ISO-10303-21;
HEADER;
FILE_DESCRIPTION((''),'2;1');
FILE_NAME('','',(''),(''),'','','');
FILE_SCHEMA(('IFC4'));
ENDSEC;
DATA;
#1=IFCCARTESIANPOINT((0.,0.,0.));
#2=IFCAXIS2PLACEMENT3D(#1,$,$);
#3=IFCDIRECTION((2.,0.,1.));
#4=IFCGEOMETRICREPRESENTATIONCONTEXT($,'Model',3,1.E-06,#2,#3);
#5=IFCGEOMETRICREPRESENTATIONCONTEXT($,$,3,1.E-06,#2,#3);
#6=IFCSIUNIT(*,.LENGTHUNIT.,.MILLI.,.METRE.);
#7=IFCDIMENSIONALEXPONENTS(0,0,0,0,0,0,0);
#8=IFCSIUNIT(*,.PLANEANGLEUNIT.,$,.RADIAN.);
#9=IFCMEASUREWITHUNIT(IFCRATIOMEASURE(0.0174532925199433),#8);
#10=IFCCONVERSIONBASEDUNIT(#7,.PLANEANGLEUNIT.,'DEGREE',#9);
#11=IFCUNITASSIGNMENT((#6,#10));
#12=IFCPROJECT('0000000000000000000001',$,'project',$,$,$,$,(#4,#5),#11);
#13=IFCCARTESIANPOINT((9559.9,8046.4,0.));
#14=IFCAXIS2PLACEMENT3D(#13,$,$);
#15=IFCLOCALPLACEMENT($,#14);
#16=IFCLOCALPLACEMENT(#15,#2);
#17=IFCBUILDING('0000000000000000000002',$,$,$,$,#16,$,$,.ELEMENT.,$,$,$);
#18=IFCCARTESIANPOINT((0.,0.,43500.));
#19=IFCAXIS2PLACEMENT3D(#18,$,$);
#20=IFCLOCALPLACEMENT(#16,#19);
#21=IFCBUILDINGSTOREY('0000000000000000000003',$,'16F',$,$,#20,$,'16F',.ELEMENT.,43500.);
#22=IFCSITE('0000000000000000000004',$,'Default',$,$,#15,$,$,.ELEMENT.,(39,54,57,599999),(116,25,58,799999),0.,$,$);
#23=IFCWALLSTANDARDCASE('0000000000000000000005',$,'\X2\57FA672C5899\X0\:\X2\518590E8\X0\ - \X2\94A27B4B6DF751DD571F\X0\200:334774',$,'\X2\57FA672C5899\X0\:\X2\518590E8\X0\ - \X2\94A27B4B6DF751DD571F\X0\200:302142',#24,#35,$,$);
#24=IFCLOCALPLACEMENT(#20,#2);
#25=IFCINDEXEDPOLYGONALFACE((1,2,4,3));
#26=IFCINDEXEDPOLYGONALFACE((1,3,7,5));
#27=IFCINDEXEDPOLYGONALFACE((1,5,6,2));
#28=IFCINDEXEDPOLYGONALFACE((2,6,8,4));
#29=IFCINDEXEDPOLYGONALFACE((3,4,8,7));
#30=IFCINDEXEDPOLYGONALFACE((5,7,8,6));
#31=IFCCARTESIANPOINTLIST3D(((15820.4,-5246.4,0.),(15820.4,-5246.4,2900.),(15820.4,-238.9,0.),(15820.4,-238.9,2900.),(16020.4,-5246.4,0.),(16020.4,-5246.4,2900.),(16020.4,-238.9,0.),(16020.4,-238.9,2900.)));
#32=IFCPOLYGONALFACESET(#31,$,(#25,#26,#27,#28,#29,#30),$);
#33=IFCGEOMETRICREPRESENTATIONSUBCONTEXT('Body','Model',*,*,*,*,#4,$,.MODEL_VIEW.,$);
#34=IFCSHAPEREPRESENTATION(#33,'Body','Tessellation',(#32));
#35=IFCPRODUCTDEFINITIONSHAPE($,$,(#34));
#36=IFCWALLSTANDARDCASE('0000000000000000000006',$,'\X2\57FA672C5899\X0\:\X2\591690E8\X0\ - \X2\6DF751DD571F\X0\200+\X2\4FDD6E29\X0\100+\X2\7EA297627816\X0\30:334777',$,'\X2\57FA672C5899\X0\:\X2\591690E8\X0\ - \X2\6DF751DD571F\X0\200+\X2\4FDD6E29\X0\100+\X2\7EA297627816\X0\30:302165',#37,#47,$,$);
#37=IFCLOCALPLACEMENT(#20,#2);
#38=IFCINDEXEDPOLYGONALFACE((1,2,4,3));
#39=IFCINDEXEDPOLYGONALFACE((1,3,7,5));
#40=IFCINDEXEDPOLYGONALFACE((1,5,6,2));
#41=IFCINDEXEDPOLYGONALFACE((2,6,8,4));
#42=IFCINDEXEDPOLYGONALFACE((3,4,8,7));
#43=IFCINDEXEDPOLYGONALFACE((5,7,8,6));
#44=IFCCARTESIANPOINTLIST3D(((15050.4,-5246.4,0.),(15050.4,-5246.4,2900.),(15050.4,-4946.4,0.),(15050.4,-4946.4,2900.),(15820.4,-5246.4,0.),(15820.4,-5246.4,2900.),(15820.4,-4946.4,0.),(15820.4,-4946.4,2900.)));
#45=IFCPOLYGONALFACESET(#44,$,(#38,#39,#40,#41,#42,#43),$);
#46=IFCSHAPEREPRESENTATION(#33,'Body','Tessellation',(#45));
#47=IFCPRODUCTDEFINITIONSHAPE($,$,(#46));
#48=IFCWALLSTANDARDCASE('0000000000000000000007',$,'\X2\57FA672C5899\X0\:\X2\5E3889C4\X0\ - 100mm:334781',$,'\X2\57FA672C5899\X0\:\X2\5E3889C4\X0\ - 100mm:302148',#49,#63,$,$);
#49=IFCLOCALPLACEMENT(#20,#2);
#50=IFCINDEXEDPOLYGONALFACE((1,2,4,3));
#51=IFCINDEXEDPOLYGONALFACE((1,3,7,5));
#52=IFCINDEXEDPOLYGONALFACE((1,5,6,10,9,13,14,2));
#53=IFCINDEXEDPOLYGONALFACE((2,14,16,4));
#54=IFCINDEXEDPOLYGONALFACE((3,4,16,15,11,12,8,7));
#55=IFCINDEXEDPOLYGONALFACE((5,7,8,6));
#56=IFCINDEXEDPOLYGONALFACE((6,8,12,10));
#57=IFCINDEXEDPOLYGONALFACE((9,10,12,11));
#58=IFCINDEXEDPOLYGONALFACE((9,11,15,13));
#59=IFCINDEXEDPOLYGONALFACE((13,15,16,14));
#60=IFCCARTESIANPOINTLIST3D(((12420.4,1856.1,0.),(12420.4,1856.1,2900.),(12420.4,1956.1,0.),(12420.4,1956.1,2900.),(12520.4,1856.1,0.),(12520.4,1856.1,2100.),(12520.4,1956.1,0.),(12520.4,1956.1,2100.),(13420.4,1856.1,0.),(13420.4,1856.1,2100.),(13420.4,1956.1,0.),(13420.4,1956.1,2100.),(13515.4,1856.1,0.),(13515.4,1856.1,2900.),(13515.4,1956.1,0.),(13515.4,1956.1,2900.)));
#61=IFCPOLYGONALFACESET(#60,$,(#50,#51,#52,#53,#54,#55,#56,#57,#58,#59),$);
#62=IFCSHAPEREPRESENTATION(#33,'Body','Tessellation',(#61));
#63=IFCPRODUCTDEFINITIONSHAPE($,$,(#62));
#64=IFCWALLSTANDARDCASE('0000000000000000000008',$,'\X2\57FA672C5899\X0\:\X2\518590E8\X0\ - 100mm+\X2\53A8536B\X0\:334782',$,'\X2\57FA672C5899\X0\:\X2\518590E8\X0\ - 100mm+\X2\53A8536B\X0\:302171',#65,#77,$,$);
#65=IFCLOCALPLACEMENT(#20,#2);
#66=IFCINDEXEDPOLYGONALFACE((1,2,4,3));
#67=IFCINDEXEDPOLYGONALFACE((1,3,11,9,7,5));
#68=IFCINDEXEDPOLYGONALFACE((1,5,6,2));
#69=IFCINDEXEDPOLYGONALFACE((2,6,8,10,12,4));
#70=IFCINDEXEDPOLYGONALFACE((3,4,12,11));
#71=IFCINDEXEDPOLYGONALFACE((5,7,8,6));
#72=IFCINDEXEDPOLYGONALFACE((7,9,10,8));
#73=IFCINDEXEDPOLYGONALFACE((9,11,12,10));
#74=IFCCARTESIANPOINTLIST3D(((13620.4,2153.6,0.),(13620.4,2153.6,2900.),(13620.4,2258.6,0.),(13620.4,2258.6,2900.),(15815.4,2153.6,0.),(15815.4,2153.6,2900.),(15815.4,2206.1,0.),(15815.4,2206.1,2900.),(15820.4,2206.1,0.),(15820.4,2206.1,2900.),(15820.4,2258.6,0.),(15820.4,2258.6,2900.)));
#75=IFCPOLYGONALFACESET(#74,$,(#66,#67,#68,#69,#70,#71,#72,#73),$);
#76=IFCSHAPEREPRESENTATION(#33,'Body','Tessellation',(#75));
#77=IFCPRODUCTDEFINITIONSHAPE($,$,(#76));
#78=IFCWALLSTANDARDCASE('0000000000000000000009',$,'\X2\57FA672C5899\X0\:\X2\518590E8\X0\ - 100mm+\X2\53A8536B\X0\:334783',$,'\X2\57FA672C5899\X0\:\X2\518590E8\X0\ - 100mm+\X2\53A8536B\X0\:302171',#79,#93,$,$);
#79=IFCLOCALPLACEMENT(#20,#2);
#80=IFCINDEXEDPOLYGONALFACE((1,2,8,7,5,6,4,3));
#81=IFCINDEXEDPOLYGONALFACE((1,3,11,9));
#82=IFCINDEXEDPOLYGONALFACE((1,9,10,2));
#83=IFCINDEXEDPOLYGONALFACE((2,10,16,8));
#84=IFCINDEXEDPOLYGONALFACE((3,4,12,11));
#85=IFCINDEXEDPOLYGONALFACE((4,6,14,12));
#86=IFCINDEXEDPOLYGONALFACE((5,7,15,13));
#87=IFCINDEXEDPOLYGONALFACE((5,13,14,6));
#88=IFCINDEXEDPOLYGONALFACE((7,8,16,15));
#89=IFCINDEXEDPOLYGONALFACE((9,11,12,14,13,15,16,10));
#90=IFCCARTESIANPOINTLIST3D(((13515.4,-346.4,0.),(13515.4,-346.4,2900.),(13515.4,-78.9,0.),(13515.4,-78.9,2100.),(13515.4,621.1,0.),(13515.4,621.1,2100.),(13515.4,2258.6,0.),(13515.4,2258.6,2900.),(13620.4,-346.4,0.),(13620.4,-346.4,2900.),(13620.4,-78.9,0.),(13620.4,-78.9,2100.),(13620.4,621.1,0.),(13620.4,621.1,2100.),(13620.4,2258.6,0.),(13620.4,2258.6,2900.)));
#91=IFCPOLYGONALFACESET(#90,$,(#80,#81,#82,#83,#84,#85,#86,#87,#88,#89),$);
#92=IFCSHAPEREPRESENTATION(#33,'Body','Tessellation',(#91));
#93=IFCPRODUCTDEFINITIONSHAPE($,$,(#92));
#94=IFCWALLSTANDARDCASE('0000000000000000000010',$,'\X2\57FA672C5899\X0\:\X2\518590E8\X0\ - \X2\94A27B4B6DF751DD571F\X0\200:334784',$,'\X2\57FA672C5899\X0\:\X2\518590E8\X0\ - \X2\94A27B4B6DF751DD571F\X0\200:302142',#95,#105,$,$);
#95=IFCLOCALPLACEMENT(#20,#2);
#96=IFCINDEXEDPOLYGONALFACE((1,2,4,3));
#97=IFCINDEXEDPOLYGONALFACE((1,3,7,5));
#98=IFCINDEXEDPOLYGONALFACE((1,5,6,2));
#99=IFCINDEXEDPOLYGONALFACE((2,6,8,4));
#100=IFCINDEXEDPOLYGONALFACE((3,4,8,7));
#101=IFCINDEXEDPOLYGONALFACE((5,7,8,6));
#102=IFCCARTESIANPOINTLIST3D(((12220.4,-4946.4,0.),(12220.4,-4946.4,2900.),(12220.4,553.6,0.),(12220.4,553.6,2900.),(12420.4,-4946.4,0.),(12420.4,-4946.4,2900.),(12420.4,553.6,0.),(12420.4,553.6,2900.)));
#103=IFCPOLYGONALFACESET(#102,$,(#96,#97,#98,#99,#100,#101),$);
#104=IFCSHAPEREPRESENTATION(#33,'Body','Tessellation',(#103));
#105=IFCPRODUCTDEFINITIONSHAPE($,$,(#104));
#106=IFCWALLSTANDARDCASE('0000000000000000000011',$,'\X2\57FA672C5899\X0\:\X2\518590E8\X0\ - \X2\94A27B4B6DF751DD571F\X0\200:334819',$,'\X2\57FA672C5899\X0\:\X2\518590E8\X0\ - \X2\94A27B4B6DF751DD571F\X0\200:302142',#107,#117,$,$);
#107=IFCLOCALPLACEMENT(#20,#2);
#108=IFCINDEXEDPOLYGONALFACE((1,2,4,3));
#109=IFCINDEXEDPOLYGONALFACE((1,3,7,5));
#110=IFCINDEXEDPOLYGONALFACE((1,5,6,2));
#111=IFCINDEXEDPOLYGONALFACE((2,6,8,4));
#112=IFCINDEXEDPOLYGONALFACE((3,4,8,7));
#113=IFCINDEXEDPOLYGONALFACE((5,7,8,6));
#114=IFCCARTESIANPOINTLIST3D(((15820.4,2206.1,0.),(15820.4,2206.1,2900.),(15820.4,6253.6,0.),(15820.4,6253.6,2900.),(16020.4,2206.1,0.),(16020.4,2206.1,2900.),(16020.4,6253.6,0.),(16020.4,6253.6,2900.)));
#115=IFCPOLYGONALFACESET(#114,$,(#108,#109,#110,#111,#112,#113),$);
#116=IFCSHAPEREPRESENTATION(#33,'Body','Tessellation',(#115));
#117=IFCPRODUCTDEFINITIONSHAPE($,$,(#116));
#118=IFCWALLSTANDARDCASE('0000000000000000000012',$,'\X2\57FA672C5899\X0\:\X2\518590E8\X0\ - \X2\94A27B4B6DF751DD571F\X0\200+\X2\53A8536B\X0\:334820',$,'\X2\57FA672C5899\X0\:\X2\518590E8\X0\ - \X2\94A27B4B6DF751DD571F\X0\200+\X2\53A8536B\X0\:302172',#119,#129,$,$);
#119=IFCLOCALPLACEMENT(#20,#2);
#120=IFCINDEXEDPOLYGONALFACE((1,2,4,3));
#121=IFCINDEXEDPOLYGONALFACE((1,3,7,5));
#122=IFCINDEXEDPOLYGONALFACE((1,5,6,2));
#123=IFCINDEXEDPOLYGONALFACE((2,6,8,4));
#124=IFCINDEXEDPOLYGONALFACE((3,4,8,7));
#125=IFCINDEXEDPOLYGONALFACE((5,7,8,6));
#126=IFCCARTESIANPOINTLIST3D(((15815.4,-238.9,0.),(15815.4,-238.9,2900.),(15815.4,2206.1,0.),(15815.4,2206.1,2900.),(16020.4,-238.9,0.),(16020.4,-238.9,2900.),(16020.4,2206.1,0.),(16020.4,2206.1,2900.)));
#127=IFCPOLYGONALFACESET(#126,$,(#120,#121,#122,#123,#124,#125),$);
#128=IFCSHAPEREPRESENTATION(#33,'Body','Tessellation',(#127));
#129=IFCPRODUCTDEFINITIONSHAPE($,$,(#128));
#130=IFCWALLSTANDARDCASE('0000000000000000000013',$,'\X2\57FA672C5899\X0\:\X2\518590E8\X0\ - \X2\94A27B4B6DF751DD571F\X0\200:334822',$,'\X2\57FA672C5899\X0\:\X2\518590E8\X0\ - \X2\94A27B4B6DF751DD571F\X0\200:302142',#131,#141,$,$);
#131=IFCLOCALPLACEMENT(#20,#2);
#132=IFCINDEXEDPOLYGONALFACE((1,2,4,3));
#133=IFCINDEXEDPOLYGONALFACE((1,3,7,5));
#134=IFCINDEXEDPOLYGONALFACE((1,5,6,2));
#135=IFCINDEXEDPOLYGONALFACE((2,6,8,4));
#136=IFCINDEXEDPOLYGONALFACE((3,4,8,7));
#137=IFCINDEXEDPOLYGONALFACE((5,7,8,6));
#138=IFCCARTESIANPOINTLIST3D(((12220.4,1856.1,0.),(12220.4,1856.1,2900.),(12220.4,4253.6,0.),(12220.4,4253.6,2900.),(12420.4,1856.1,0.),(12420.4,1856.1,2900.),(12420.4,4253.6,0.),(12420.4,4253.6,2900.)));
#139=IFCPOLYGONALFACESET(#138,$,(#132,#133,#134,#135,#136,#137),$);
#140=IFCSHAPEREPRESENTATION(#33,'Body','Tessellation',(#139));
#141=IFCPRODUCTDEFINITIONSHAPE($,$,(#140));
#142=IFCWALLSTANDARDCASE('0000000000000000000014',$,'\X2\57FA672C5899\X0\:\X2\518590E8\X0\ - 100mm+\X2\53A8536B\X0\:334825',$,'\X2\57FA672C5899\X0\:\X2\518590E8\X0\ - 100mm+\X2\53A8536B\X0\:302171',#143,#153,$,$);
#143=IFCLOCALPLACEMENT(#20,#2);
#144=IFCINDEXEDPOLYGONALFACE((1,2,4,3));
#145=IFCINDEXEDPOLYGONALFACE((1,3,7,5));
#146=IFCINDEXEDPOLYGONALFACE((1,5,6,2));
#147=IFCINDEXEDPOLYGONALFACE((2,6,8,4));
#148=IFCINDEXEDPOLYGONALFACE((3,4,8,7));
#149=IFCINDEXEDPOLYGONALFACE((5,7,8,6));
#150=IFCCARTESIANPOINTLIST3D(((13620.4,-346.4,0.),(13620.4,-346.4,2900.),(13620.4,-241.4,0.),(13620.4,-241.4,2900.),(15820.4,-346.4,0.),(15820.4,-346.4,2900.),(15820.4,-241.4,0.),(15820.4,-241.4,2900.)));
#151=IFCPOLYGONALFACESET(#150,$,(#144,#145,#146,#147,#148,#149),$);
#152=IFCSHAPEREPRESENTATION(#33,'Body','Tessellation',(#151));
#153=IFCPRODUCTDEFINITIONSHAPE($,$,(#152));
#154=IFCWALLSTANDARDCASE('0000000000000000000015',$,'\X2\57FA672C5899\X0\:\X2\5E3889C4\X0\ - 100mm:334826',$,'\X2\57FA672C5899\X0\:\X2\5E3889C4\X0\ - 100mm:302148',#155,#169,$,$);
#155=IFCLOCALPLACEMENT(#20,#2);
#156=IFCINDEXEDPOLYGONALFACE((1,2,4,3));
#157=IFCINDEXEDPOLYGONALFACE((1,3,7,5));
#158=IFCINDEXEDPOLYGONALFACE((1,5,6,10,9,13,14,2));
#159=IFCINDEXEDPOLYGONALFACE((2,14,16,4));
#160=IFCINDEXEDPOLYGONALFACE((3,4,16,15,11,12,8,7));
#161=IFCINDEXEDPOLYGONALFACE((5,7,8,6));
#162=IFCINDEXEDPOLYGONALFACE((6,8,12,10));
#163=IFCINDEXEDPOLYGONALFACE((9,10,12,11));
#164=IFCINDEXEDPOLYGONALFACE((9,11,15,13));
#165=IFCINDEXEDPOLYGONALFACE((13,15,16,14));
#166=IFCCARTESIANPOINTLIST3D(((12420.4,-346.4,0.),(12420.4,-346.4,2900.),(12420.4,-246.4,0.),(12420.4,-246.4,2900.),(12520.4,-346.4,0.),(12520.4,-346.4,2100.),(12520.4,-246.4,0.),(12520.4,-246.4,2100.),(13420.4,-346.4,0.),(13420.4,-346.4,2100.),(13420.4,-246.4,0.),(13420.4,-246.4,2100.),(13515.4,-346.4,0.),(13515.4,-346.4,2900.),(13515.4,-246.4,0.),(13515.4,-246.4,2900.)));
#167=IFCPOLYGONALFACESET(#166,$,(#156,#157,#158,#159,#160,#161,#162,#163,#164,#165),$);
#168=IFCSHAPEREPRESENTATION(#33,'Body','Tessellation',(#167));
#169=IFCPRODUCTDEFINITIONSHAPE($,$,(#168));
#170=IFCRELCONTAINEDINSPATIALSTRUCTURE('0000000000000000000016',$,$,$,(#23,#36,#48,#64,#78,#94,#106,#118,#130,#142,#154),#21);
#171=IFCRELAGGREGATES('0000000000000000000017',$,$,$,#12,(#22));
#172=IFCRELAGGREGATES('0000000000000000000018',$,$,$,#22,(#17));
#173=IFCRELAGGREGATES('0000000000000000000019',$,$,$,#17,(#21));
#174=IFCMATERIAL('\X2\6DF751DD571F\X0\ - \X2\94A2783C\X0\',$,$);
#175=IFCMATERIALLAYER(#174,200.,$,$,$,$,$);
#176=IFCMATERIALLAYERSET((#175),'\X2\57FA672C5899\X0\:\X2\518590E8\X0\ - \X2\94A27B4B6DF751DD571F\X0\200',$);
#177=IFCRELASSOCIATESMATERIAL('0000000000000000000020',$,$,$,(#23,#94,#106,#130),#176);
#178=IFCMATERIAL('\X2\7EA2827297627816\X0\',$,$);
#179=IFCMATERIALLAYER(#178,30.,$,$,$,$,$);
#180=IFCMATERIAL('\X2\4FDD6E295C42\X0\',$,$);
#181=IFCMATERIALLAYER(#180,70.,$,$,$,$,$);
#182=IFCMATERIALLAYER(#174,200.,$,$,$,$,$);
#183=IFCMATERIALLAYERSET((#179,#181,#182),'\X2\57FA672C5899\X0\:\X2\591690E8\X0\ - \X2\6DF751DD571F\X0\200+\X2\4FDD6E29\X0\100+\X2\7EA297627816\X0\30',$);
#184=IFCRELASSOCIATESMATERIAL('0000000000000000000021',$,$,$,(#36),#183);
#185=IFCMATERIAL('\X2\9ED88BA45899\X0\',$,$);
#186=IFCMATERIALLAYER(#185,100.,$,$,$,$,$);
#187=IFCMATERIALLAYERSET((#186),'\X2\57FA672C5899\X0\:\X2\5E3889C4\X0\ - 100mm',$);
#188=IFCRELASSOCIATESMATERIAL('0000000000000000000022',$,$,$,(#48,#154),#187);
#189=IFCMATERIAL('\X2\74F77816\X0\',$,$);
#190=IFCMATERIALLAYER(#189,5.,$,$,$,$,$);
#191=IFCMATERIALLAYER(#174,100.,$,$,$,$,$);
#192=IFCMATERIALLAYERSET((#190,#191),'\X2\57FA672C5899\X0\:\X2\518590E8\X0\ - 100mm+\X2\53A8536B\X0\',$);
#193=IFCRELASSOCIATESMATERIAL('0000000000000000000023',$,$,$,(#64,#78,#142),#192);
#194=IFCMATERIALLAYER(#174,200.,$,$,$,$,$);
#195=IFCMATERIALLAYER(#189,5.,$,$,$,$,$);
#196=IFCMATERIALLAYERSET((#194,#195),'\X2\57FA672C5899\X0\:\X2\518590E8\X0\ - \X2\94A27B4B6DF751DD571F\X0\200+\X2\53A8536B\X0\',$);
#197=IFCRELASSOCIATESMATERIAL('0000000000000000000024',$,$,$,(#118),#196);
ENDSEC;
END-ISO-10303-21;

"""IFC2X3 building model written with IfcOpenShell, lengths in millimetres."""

from ifc_helpers import new_model, entity, si_unit, converted_unit, direction, frame, frame_2d, origin, place, context, subcontext, project, spatial, polyline, rectangle, outline, extrude, material, layer, layer_set, layer_usage, element, save


model = new_model("IFC2X3")

# Units and contexts
model_context = context("Model", 3, precision=1e-06, world=origin(), true_north=direction((2.0, 0.0, 1.0)))
context_of_model = context(None, 3, precision=1e-06, world=origin(), true_north=direction((2.0, 0.0, 1.0)))
body_context = subcontext(model_context, "Body", "Model", "MODEL_VIEW")
ifc_project = project(units=[si_unit("LENGTHUNIT", "METRE", prefix="MILLI"), converted_unit("PLANEANGLEUNIT", "DEGREE", entity("IfcRatioMeasure", 0.0174532925199433), si_unit("PLANEANGLEUNIT", "RADIAN"), dimensions=[0, 0, 0, 0, 0, 0, 0])], contexts=[model_context, context_of_model])

# Site, building, storey
site_placement = place(None, frame((9559.9, 8046.4, 0.0)))
site = spatial("IfcSite", under=ifc_project, at=site_placement, Name="Default", CompositionType="ELEMENT", RefLatitude=(39, 54, 57, 599999), RefLongitude=(116, 25, 58, 799999), RefElevation=0.0)
building_placement = place(site_placement, origin())
building = spatial("IfcBuilding", under=site, at=building_placement, CompositionType="ELEMENT")
storey_placement = place(building_placement, frame((0.0, 0.0, 43500.0)))
storey = spatial("IfcBuildingStorey", under=building, at=storey_placement, Name="16F", LongName="16F", CompositionType="ELEMENT", Elevation=43500.0)

# Walls
ifc_material_1 = material(Name="混凝土 - 钢砼")
ifc_layer_1 = layer(ifc_material_1, 200.0)
ifc_layer_set_1 = layer_set([ifc_layer_1], Name="基本墙:内部 - 钢筋混凝土200")
ifc_layer_usage_1 = layer_usage(ifc_layer_set_1, "AXIS2", "POSITIVE", -100.0)
wall_1_placement = place(storey_placement, frame((15920.4, -5246.4, 0.0), z_axis=(0.0, 0.0, 1.0), x_axis=(0.0, 1.0, 0.0)))
element("IfcWallStandardCase", 1, at=wall_1_placement, inside=storey, material=ifc_layer_usage_1, Name="基本墙:内部 - 钢筋混凝土200:334774", ObjectType="基本墙:内部 - 钢筋混凝土200:302142", context=body_context, shape_type="SweptSolid", body=[
    extrude(rectangle(XDim=5007.5, YDim=200.0, at=frame_2d((2503.8, 0.0), x_axis=(-1.0, 0.0))), origin(), (0.0, 0.0, 1.0), 2900.0),
])
ifc_material_2 = material(Name="红色面砖")
ifc_layer_2 = layer(ifc_material_2, 30.0)
ifc_material_3 = material(Name="保温层")
ifc_layer_3 = layer(ifc_material_3, 70.0)
ifc_layer_4 = layer(ifc_material_1, 200.0)
ifc_layer_set_2 = layer_set([ifc_layer_2, ifc_layer_3, ifc_layer_4], Name="基本墙:外部 - 混凝土200+保温100+红面砖30")
ifc_layer_usage_2 = layer_usage(ifc_layer_set_2, "AXIS2", "NEGATIVE", 150.0)
wall_2_placement = place(storey_placement, frame((15820.4, -5096.4, 0.0), z_axis=(0.0, 0.0, 1.0), x_axis=(-1.0, 0.0, 0.0)))
element("IfcWallStandardCase", 2, at=wall_2_placement, inside=storey, material=ifc_layer_usage_2, Name="基本墙:外部 - 混凝土200+保温100+红面砖30:334777", ObjectType="基本墙:外部 - 混凝土200+保温100+红面砖30:302165", context=body_context, shape_type="SweptSolid", body=[
    extrude(rectangle(XDim=770.0, YDim=300.0, at=frame_2d((385.0, 0.0), x_axis=(-1.0, 0.0))), origin(), (0.0, 0.0, 1.0), 2900.0),
])

# Wall, opening
ifc_material_4 = material(Name="默认墙")
ifc_layer_5 = layer(ifc_material_4, 100.0)
ifc_layer_set_3 = layer_set([ifc_layer_5], Name="基本墙:常规 - 100mm")
ifc_layer_usage_3 = layer_usage(ifc_layer_set_3, "AXIS2", "POSITIVE", -50.0)
wall_3_placement = place(storey_placement, frame((13515.4, 1906.1, 0.0), z_axis=(0.0, 0.0, 1.0), x_axis=(-1.0, 0.0, 0.0)))
wall_3 = element("IfcWallStandardCase", 3, at=wall_3_placement, inside=storey, material=ifc_layer_usage_3, Name="基本墙:常规 - 100mm:334781", ObjectType="基本墙:常规 - 100mm:302148", context=body_context, shape_type="SweptSolid", body=[
    extrude(rectangle(XDim=1095.0, YDim=100.0, at=frame_2d((547.5, 0.0), x_axis=(-1.0, 0.0))), origin(), (0.0, 0.0, 1.0), 2900.0),
])
opening_1_placement = place(wall_3_placement, frame((995.0, 50.0, 0.0)))
element("IfcOpeningElement", 4, at=opening_1_placement, cuts=wall_3, ObjectType="Opening", context=body_context, shape_type="SweptSolid", body=[
    extrude(rectangle(XDim=2100.0, YDim=900.0, at=frame_2d((1050.0, 450.0), x_axis=(1.0, 0.0))), frame((0.0, 0.0, 0.0), z_axis=(0.0, -1.0, 0.0), x_axis=(0.0, 0.0, 1.0)), (0.0, 0.0, 1.0), 100.0),
])

# Wall
ifc_material_5 = material(Name="瓷砖")
ifc_layer_6 = layer(ifc_material_5, 5.0)
ifc_layer_7 = layer(ifc_material_1, 100.0)
ifc_layer_set_4 = layer_set([ifc_layer_6, ifc_layer_7], Name="基本墙:内部 - 100mm+厨卫")
ifc_layer_usage_4 = layer_usage(ifc_layer_set_4, "AXIS2", "NEGATIVE", 52.5)
wall_4_placement = place(storey_placement, frame((15820.4, 2206.1, 0.0), z_axis=(0.0, 0.0, 1.0), x_axis=(-1.0, 0.0, 0.0)))
element("IfcWallStandardCase", 5, at=wall_4_placement, inside=storey, material=ifc_layer_usage_4, Name="基本墙:内部 - 100mm+厨卫:334782", ObjectType="基本墙:内部 - 100mm+厨卫:302171", context=body_context, shape_type="SweptSolid", body=[
    extrude(outline(polyline([(2200.0, -52.5), (2200.0, 52.5), (5.0, 52.5), (5.0, 0.0), (0.0, 0.0), (0.0, -52.5), (2200.0, -52.5)])), origin(), (0.0, 0.0, 1.0), 2900.0),
])

# Wall, opening
ifc_layer_usage_5 = layer_usage(ifc_layer_set_4, "AXIS2", "NEGATIVE", 52.5)
wall_5_placement = place(storey_placement, frame((13567.9, 2258.6, 0.0), z_axis=(0.0, 0.0, 1.0), x_axis=(0.0, -1.0, 0.0)))
wall_5 = element("IfcWallStandardCase", 6, at=wall_5_placement, inside=storey, material=ifc_layer_usage_5, Name="基本墙:内部 - 100mm+厨卫:334783", ObjectType="基本墙:内部 - 100mm+厨卫:302171", context=body_context, shape_type="SweptSolid", body=[
    extrude(rectangle(XDim=2605.0, YDim=105.0, at=frame_2d((1302.5, 0.0), x_axis=(-1.0, 0.0))), origin(), (0.0, 0.0, 1.0), 2900.0),
])
opening_2_placement = place(wall_5_placement, frame((1637.5, -52.5, 0.0)))
element("IfcOpeningElement", 7, at=opening_2_placement, cuts=wall_5, ObjectType="Opening", context=body_context, shape_type="SweptSolid", body=[
    extrude(rectangle(XDim=2100.0, YDim=700.0, at=frame_2d((1050.0, 350.0), x_axis=(1.0, 0.0))), frame((0.0, 0.0, 0.0), z_axis=(0.0, 1.0, 0.0), x_axis=(0.0, 0.0, 1.0)), (0.0, 0.0, 1.0), 105.0),
])

# Walls
ifc_layer_usage_6 = layer_usage(ifc_layer_set_1, "AXIS2", "NEGATIVE", 100.0)
wall_6_placement = place(storey_placement, frame((12320.4, 553.6, 0.0), z_axis=(0.0, 0.0, 1.0), x_axis=(0.0, -1.0, 0.0)))
element("IfcWallStandardCase", 8, at=wall_6_placement, inside=storey, material=ifc_layer_usage_6, Name="基本墙:内部 - 钢筋混凝土200:334784", ObjectType="基本墙:内部 - 钢筋混凝土200:302142", context=body_context, shape_type="SweptSolid", body=[
    extrude(rectangle(XDim=5500.0, YDim=200.0, at=frame_2d((2750.0, 0.0), x_axis=(-1.0, 0.0))), origin(), (0.0, 0.0, 1.0), 2900.0),
])
ifc_layer_usage_7 = layer_usage(ifc_layer_set_1, "AXIS2", "POSITIVE", -100.0)
wall_7_placement = place(storey_placement, frame((15920.4, 2206.1, 0.0), z_axis=(0.0, 0.0, 1.0), x_axis=(0.0, 1.0, 0.0)))
element("IfcWallStandardCase", 9, at=wall_7_placement, inside=storey, material=ifc_layer_usage_7, Name="基本墙:内部 - 钢筋混凝土200:334819", ObjectType="基本墙:内部 - 钢筋混凝土200:302142", context=body_context, shape_type="SweptSolid", body=[
    extrude(rectangle(XDim=4047.5, YDim=200.0, at=frame_2d((2023.8, 0.0), x_axis=(-1.0, 0.0))), origin(), (0.0, 0.0, 1.0), 2900.0),
])
ifc_layer_8 = layer(ifc_material_1, 200.0)
ifc_layer_9 = layer(ifc_material_5, 5.0)
ifc_layer_set_5 = layer_set([ifc_layer_8, ifc_layer_9], Name="基本墙:内部 - 钢筋混凝土200+厨卫")
ifc_layer_usage_8 = layer_usage(ifc_layer_set_5, "AXIS2", "POSITIVE", -102.5)
wall_8_placement = place(storey_placement, frame((15917.9, -238.9, 0.0), z_axis=(0.0, 0.0, 1.0), x_axis=(0.0, 1.0, 0.0)))
element("IfcWallStandardCase", 10, at=wall_8_placement, inside=storey, material=ifc_layer_usage_8, Name="基本墙:内部 - 钢筋混凝土200+厨卫:334820", ObjectType="基本墙:内部 - 钢筋混凝土200+厨卫:302172", context=body_context, shape_type="SweptSolid", body=[
    extrude(rectangle(XDim=2445.0, YDim=205.0, at=frame_2d((1222.5, 0.0), x_axis=(-1.0, 0.0))), origin(), (0.0, 0.0, 1.0), 2900.0),
])
ifc_layer_usage_9 = layer_usage(ifc_layer_set_1, "AXIS2", "POSITIVE", -100.0)
wall_9_placement = place(storey_placement, frame((12320.4, 4253.6, 0.0), z_axis=(0.0, 0.0, 1.0), x_axis=(0.0, -1.0, 0.0)))
element("IfcWallStandardCase", 11, at=wall_9_placement, inside=storey, material=ifc_layer_usage_9, Name="基本墙:内部 - 钢筋混凝土200:334822", ObjectType="基本墙:内部 - 钢筋混凝土200:302142", context=body_context, shape_type="SweptSolid", body=[
    extrude(rectangle(XDim=2397.5, YDim=200.0, at=frame_2d((1198.8, 0.0), x_axis=(-1.0, 0.0))), origin(), (0.0, 0.0, 1.0), 2900.0),
])
ifc_layer_usage_10 = layer_usage(ifc_layer_set_4, "AXIS2", "POSITIVE", -52.5)
wall_10_placement = place(storey_placement, frame((15820.4, -293.9, 0.0), z_axis=(0.0, 0.0, 1.0), x_axis=(-1.0, 0.0, 0.0)))
element("IfcWallStandardCase", 12, at=wall_10_placement, inside=storey, material=ifc_layer_usage_10, Name="基本墙:内部 - 100mm+厨卫:334825", ObjectType="基本墙:内部 - 100mm+厨卫:302171", context=body_context, shape_type="SweptSolid", body=[
    extrude(rectangle(XDim=2200.0, YDim=105.0, at=frame_2d((1100.0, 0.0), x_axis=(-1.0, 0.0))), origin(), (0.0, 0.0, 1.0), 2900.0),
])

# Wall, opening
ifc_layer_usage_11 = layer_usage(ifc_layer_set_3, "AXIS2", "POSITIVE", -50.0)
wall_11_placement = place(storey_placement, frame((13515.4, -296.4, 0.0), z_axis=(0.0, 0.0, 1.0), x_axis=(-1.0, 0.0, 0.0)))
wall_11 = element("IfcWallStandardCase", 13, at=wall_11_placement, inside=storey, material=ifc_layer_usage_11, Name="基本墙:常规 - 100mm:334826", ObjectType="基本墙:常规 - 100mm:302148", context=body_context, shape_type="SweptSolid", body=[
    extrude(rectangle(XDim=1095.0, YDim=100.0, at=frame_2d((547.5, 0.0), x_axis=(-1.0, 0.0))), origin(), (0.0, 0.0, 1.0), 2900.0),
])
opening_3_placement = place(wall_11_placement, frame((95.0, -50.0, 0.0)))
element("IfcOpeningElement", 14, at=opening_3_placement, cuts=wall_11, ObjectType="Opening", context=body_context, shape_type="SweptSolid", body=[
    extrude(rectangle(XDim=2100.0, YDim=900.0, at=frame_2d((1050.0, 450.0), x_axis=(1.0, 0.0))), frame((0.0, 0.0, 0.0), z_axis=(0.0, 1.0, 0.0), x_axis=(0.0, 0.0, 1.0)), (0.0, 0.0, 1.0), 100.0),
])

save(model, "model.ifc")
